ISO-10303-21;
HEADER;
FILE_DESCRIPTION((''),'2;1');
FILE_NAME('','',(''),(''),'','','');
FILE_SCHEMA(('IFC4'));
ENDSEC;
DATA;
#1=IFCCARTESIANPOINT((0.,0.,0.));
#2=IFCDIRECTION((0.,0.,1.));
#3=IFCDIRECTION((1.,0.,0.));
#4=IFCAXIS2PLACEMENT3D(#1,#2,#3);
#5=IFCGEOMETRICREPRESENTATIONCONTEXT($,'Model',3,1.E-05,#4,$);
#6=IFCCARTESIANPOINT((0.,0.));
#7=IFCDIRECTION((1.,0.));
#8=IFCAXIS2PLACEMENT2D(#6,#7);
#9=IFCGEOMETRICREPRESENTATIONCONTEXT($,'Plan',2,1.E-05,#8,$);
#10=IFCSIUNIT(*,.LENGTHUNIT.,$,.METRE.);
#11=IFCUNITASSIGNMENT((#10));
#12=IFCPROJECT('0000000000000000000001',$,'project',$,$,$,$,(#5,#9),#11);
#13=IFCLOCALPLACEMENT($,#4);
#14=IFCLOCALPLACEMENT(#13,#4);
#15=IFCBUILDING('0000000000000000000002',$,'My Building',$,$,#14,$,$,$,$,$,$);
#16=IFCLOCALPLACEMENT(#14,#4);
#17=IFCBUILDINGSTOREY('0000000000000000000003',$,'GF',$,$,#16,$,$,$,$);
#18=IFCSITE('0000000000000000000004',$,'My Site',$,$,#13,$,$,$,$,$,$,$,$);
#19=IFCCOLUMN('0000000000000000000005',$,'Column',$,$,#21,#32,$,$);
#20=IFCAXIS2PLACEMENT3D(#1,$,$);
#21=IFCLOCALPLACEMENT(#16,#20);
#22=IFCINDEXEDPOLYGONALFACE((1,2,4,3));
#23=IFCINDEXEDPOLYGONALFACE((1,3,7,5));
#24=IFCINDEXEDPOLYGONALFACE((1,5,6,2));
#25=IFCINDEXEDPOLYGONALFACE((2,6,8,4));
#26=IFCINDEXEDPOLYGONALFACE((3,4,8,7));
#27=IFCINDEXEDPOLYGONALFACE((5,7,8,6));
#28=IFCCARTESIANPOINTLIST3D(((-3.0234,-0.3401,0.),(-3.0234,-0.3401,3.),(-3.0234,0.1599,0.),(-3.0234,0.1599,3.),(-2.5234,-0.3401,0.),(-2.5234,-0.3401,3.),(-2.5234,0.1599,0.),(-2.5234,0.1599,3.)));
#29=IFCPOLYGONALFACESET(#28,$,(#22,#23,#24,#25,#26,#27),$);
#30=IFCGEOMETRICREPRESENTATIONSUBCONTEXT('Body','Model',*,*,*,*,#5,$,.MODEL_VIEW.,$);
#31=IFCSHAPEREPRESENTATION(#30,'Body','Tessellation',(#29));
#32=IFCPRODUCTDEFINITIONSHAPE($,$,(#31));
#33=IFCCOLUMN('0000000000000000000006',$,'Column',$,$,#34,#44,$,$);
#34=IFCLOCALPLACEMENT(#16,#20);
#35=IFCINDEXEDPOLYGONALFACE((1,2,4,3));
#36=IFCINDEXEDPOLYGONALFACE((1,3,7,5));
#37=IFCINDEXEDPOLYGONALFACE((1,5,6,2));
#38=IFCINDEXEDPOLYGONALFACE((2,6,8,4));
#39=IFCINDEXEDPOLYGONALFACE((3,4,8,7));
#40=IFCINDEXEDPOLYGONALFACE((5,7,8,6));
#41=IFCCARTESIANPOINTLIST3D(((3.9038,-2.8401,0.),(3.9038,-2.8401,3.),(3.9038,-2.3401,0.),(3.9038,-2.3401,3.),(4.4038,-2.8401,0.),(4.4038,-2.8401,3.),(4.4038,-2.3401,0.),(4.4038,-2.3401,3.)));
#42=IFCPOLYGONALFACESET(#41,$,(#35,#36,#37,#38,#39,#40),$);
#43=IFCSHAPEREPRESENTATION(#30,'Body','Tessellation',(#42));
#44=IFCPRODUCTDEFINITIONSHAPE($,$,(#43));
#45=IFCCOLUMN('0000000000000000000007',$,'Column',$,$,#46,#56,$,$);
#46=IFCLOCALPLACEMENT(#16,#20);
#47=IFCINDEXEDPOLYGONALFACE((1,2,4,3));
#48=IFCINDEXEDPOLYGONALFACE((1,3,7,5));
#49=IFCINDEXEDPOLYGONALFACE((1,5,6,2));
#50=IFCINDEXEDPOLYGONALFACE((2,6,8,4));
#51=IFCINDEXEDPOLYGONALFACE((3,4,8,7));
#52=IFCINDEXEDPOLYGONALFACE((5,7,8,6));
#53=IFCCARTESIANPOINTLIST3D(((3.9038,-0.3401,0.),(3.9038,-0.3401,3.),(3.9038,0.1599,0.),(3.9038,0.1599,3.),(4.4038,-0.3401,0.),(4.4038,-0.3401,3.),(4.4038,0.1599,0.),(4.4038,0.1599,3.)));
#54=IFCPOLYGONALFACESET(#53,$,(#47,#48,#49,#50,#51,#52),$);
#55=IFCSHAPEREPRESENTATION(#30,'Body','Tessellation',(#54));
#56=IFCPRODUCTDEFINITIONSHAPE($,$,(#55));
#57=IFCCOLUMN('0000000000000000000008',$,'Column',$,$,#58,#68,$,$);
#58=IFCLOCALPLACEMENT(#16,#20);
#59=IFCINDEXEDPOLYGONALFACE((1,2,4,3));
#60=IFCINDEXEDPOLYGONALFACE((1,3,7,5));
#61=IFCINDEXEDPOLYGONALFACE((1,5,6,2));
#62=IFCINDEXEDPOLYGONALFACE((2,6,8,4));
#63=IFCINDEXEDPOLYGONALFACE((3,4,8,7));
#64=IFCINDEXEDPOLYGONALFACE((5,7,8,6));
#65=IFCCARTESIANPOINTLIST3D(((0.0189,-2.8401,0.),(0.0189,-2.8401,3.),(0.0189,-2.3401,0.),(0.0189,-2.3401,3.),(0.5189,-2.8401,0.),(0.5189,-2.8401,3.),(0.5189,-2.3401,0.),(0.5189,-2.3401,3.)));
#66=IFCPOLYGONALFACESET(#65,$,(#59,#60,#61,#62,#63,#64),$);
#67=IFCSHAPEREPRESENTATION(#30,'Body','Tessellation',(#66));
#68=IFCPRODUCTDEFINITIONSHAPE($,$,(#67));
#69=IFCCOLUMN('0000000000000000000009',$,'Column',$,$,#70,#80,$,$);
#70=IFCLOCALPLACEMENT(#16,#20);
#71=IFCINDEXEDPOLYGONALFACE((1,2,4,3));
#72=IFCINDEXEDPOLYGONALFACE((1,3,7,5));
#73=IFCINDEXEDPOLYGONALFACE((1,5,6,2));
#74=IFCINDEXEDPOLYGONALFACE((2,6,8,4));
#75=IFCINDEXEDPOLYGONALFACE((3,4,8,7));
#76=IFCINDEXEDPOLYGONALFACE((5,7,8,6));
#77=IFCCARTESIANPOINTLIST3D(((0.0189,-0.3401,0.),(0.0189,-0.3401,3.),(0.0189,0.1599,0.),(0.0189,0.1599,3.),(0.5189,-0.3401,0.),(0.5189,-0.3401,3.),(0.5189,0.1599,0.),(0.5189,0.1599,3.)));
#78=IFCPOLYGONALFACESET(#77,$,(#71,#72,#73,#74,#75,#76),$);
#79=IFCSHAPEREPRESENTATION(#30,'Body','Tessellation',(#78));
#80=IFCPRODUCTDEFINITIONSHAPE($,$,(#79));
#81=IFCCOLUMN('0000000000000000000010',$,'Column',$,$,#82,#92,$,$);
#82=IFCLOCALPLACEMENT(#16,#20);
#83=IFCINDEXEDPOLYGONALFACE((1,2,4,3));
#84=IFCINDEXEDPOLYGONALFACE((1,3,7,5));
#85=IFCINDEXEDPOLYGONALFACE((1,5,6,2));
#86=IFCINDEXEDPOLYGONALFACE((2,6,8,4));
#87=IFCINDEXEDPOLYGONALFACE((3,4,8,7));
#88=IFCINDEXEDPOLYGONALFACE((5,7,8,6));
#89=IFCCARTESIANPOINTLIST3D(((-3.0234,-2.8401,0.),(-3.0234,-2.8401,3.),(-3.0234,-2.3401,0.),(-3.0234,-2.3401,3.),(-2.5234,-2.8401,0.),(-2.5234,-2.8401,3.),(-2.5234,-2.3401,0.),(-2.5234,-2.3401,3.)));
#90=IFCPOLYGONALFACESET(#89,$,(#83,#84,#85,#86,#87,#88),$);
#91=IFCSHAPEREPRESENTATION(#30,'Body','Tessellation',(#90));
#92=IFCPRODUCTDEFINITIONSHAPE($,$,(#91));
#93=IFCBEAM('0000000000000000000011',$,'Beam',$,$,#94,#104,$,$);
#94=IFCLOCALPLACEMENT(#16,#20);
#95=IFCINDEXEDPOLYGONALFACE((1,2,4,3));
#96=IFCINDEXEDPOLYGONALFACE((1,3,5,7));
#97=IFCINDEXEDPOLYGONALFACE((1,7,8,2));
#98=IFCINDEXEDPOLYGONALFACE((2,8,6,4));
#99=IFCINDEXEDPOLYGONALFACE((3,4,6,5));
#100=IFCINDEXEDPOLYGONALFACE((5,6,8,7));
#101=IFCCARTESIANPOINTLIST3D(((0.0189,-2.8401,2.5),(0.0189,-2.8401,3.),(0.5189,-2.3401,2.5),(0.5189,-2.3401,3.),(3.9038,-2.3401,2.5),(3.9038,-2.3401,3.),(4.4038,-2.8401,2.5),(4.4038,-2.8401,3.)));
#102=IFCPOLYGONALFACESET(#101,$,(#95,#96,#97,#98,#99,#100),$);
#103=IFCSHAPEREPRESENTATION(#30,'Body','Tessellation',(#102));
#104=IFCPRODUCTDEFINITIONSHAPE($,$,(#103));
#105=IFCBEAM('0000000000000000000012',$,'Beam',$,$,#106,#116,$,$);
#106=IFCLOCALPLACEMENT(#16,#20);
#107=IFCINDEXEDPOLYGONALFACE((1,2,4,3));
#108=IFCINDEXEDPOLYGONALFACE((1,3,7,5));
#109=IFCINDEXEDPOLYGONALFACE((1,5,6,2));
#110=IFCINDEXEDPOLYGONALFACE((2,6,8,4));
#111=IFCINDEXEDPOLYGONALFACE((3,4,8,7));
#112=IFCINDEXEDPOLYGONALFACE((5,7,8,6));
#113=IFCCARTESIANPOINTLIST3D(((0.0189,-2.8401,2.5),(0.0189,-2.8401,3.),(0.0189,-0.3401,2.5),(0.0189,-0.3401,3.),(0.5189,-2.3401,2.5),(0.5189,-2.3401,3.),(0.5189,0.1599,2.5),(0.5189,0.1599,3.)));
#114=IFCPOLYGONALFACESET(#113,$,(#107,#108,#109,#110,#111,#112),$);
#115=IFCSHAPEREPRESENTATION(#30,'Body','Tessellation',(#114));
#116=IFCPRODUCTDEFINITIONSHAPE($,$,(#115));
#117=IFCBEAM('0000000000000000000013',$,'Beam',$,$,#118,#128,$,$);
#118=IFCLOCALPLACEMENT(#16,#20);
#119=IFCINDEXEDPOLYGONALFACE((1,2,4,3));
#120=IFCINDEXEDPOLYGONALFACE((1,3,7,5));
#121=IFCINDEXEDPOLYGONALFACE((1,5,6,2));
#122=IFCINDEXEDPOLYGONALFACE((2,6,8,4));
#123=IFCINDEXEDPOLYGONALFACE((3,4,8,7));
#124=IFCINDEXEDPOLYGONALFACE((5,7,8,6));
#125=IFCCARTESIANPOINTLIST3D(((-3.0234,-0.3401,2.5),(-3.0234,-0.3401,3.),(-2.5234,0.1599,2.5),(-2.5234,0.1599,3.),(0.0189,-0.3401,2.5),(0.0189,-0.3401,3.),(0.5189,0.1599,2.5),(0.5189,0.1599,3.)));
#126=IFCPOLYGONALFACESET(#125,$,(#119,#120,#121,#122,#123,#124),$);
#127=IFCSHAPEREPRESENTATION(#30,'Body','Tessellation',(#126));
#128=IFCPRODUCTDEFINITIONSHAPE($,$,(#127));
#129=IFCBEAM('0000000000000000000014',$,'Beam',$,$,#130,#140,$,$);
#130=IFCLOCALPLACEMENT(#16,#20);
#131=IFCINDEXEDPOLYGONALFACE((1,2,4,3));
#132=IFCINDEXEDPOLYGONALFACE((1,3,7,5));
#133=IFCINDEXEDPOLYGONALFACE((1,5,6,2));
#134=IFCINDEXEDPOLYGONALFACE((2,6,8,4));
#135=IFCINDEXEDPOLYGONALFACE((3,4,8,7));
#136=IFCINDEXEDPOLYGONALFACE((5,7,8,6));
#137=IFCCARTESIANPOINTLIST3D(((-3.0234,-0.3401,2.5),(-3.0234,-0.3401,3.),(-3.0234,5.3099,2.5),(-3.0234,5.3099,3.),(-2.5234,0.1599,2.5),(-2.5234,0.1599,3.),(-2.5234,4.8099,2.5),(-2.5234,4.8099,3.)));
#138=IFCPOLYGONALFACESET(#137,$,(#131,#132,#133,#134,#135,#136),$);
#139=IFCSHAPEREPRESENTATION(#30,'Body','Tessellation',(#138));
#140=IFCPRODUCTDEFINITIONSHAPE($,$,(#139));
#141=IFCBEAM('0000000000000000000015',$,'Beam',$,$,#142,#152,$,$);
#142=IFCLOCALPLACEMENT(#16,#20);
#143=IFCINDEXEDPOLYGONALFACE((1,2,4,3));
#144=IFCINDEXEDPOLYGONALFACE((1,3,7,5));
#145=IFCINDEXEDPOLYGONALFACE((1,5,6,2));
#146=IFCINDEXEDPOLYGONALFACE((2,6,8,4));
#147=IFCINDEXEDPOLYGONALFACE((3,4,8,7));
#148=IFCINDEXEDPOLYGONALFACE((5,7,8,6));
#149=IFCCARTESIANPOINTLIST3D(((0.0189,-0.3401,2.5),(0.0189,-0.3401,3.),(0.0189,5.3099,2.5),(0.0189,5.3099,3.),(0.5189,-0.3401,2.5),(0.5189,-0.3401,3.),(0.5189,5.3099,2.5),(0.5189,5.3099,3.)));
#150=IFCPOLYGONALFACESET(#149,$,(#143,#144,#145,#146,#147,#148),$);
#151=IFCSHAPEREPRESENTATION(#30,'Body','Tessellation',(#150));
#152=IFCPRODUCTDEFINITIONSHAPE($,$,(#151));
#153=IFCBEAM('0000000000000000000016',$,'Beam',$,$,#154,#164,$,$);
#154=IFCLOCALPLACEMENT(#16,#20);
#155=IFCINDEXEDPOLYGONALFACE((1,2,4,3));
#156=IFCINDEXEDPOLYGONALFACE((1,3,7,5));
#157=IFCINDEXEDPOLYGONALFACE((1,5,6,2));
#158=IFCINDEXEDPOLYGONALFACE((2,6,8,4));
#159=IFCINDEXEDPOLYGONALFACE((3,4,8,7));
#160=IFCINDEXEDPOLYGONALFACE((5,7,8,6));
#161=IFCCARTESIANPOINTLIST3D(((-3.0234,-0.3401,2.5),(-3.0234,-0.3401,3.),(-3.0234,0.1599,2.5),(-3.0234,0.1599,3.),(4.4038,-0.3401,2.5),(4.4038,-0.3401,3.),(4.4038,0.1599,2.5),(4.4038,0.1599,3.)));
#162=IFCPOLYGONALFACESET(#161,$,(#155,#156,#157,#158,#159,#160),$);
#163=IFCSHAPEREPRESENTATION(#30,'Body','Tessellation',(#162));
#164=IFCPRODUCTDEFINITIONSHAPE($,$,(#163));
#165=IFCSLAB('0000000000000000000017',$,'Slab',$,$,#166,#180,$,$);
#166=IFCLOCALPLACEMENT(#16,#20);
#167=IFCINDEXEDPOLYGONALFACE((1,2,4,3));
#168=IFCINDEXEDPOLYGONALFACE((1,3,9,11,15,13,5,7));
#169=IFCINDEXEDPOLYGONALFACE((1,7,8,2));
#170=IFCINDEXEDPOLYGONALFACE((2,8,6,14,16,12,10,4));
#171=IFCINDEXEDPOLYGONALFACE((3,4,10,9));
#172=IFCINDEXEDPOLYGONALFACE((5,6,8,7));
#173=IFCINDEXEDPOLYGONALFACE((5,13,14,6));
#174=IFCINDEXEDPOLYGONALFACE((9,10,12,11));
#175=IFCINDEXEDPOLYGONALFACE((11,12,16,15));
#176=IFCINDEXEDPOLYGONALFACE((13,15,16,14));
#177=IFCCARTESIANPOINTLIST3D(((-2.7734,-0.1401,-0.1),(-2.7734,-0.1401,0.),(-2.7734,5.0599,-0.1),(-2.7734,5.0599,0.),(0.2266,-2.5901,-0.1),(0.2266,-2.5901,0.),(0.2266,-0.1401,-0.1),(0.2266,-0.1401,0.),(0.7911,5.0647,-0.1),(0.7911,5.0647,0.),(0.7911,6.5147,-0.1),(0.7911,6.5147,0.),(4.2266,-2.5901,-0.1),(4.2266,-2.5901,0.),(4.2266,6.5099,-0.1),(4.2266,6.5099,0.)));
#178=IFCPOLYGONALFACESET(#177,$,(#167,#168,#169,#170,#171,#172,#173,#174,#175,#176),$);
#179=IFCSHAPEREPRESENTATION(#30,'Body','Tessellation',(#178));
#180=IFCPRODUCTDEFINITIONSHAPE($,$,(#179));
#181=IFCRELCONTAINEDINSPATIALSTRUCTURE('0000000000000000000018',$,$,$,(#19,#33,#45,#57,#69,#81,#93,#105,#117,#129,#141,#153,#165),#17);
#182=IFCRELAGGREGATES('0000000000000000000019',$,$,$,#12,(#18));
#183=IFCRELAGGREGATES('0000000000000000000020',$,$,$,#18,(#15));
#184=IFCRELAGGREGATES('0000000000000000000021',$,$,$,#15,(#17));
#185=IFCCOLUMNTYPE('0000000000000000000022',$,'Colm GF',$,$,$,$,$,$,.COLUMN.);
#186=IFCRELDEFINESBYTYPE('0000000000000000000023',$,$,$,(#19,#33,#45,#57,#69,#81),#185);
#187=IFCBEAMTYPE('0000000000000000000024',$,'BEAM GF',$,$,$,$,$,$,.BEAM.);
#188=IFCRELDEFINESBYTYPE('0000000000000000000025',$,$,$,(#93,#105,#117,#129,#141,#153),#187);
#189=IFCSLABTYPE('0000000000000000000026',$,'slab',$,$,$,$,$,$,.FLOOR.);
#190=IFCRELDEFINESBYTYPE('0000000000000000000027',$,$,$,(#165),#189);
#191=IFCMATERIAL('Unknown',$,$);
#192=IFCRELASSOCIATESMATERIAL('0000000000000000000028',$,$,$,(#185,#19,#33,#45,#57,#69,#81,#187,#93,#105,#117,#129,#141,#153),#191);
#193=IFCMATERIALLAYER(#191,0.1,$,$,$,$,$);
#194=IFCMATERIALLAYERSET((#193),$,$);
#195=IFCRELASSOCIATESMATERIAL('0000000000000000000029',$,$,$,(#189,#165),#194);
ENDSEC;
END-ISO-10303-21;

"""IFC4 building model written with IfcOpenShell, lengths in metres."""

from ifc_helpers import new_model, si_unit, frame, origin_with_axes, origin_2d_with_axis, place, context, subcontext, project, spatial, indexed_curve, rectangle, outline, extrude, clip, halfspace, material, layer, layer_set, layer_usage, material_profile, profile_set, profile_usage, type_object, element, save


model = new_model("IFC4")

# Units and contexts
model_context = context("Model", 3, precision=1e-05, world=origin_with_axes())
plan_context = context("Plan", 2, precision=1e-05, world=origin_2d_with_axis())
body_context_1 = subcontext(model_context, "Body", "Model", "MODEL_VIEW")
ifc_project = project(units=[si_unit("LENGTHUNIT", "METRE")], contexts=[model_context, plan_context])

# Site, building, storey
site_placement = place(None, origin_with_axes())
site = spatial("IfcSite", under=ifc_project, at=site_placement, Name="My Site")
building_placement = place(site_placement, origin_with_axes())
building = spatial("IfcBuilding", under=site, at=building_placement, Name="My Building")
storey_placement = place(building_placement, origin_with_axes())
storey = spatial("IfcBuildingStorey", under=building, at=storey_placement, Name="GF")

# Columns
ifc_material = material(Name="Unknown")
ifc_material_profile_1 = material_profile(ifc_material, rectangle(XDim=0.5, YDim=0.5))
ifc_profile_set_1 = profile_set([ifc_material_profile_1])
ifc_profile_usage_1 = profile_usage(ifc_profile_set_1, cardinal=5)
column_type = type_object("IfcColumnType", Name="Colm GF", PredefinedType="COLUMN", material=ifc_profile_set_1)
column_1_placement = place(storey_placement, frame((-2.7734, -0.0901, 0.0), z_axis=(0.0, 0.0, 1.0), x_axis=(1.0, 0.0, 0.0)))
element("IfcColumn", 1, at=column_1_placement, inside=storey, type_object=column_type, material=ifc_profile_usage_1, Name="Column", context=body_context_1, shape_type="SweptSolid", body=[
    extrude(rectangle(XDim=0.5, YDim=0.5), origin_with_axes(), (0.0, 0.0, 1.0), 3.0),
])
ifc_profile_usage_2 = profile_usage(ifc_profile_set_1, cardinal=5)
column_2_placement = place(storey_placement, frame((4.1538, -2.5901, 0.0), z_axis=(0.0, 0.0, 1.0), x_axis=(1.0, 0.0, 0.0)))
element("IfcColumn", 2, at=column_2_placement, inside=storey, type_object=column_type, material=ifc_profile_usage_2, Name="Column", context=body_context_1, shape_type="SweptSolid", body=[
    extrude(rectangle(XDim=0.5, YDim=0.5), origin_with_axes(), (0.0, 0.0, 1.0), 3.0),
])
ifc_profile_usage_3 = profile_usage(ifc_profile_set_1, cardinal=5)
column_3_placement = place(storey_placement, frame((4.1538, -0.0901, 0.0), z_axis=(0.0, 0.0, 1.0), x_axis=(1.0, 0.0, 0.0)))
element("IfcColumn", 3, at=column_3_placement, inside=storey, type_object=column_type, material=ifc_profile_usage_3, Name="Column", context=body_context_1, shape_type="SweptSolid", body=[
    extrude(rectangle(XDim=0.5, YDim=0.5), origin_with_axes(), (0.0, 0.0, 1.0), 3.0),
])
ifc_profile_usage_4 = profile_usage(ifc_profile_set_1, cardinal=5)
column_4_placement = place(storey_placement, frame((0.2689, -2.5901, 0.0), z_axis=(0.0, 0.0, 1.0), x_axis=(1.0, 0.0, 0.0)))
element("IfcColumn", 4, at=column_4_placement, inside=storey, type_object=column_type, material=ifc_profile_usage_4, Name="Column", context=body_context_1, shape_type="SweptSolid", body=[
    extrude(rectangle(XDim=0.5, YDim=0.5), origin_with_axes(), (0.0, 0.0, 1.0), 3.0),
])
ifc_profile_usage_5 = profile_usage(ifc_profile_set_1, cardinal=5)
column_5_placement = place(storey_placement, frame((0.2689, -0.0901, 0.0), z_axis=(0.0, 0.0, 1.0), x_axis=(1.0, 0.0, 0.0)))
element("IfcColumn", 5, at=column_5_placement, inside=storey, type_object=column_type, material=ifc_profile_usage_5, Name="Column", context=body_context_1, shape_type="SweptSolid", body=[
    extrude(rectangle(XDim=0.5, YDim=0.5), origin_with_axes(), (0.0, 0.0, 1.0), 3.0),
])
ifc_profile_usage_6 = profile_usage(ifc_profile_set_1, cardinal=5)
column_6_placement = place(storey_placement, frame((-2.7734, -2.5901, 0.0), z_axis=(0.0, 0.0, 1.0), x_axis=(1.0, 0.0, 0.0)))
element("IfcColumn", 6, at=column_6_placement, inside=storey, type_object=column_type, material=ifc_profile_usage_6, Name="Column", context=body_context_1, shape_type="SweptSolid", body=[
    extrude(rectangle(XDim=0.5, YDim=0.5), origin_with_axes(), (0.0, 0.0, 1.0), 3.0),
])

# Beams
ifc_material_profile_2 = material_profile(ifc_material, rectangle(XDim=0.5, YDim=0.5))
ifc_profile_set_2 = profile_set([ifc_material_profile_2])
ifc_profile_usage_7 = profile_usage(ifc_profile_set_2, cardinal=7)
beam_type = type_object("IfcBeamType", Name="BEAM GF", PredefinedType="BEAM", material=ifc_profile_set_2)
beam_1_placement = place(storey_placement, frame((4.4038, -2.8401, 3.0), z_axis=(-1.0, 0.0, 0.0), x_axis=(0.0, -1.0, 0.0)))
element("IfcBeam", 7, at=beam_1_placement, inside=storey, type_object=beam_type, material=ifc_profile_usage_7, Name="Beam", context=body_context_1, shape_type="Clipping", body=[
    clip(clip(extrude(rectangle(XDim=0.5, YDim=0.5), frame((-0.25, -0.25, 0.0), z_axis=(0.0, 0.0, 1.0), x_axis=(1.0, 0.0, 0.0)), (0.0, 0.0, 1.0), 4.3849), halfspace(frame((0.0, -3.0, 4.3849), z_axis=(-0.707107, 0.0, 0.707107), x_axis=(0.0, 1.0, 0.0)), False)), halfspace(frame((0.0, -3.0, 0.0), z_axis=(-0.707107, 0.0, -0.707107), x_axis=(0.0, 1.0, 0.0)), False)),
])
ifc_profile_usage_8 = profile_usage(ifc_profile_set_2, cardinal=7)
beam_2_placement = place(storey_placement, frame((0.0189, -2.8401, 3.0), z_axis=(0.0, 1.0, 0.0), x_axis=(-1.0, 0.0, 0.0)))
element("IfcBeam", 8, at=beam_2_placement, inside=storey, type_object=beam_type, material=ifc_profile_usage_8, Name="Beam", context=body_context_1, shape_type="Clipping", body=[
    clip(clip(extrude(rectangle(XDim=0.5, YDim=0.5), frame((-0.25, -0.25, 0.0), z_axis=(0.0, 0.0, 1.0), x_axis=(1.0, 0.0, 0.0)), (0.0, 0.0, 1.0), 3.0), halfspace(frame((-0.5, -3.0, 3.0), z_axis=(0.707107, 0.0, 0.707107), x_axis=(0.0, -1.0, 0.0)), False)), halfspace(frame((0.0, -3.0, 0.0), z_axis=(-0.707107, 0.0, -0.707107), x_axis=(0.0, 1.0, 0.0)), False)),
])
ifc_profile_usage_9 = profile_usage(ifc_profile_set_2, cardinal=7)
beam_3_placement = place(storey_placement, frame((0.5189, -0.3401, 3.0), z_axis=(-1.0, 0.0, 0.0), x_axis=(0.0, -1.0, 0.0)))
element("IfcBeam", 9, at=beam_3_placement, inside=storey, type_object=beam_type, material=ifc_profile_usage_9, Name="Beam", context=body_context_1, shape_type="Clipping", body=[
    clip(clip(extrude(rectangle(XDim=0.5, YDim=0.5), frame((-0.25, -0.25, 0.0), z_axis=(0.0, 0.0, 1.0), x_axis=(1.0, 0.0, 0.0)), (0.0, 0.0, 1.0), 3.5422), halfspace(frame((0.0, -3.0, 3.5422), z_axis=(-0.707107, 0.0, 0.707107), x_axis=(0.0, 1.0, 0.0)), False)), halfspace(frame((-0.5, -3.0, 0.0), z_axis=(0.707107, 0.0, -0.707107), x_axis=(0.0, -1.0, 0.0)), False)),
])
ifc_profile_usage_10 = profile_usage(ifc_profile_set_2, cardinal=7)
beam_4_placement = place(storey_placement, frame((-3.0234, -0.3401, 3.0), z_axis=(0.0, 1.0, 0.0), x_axis=(-1.0, 0.0, 0.0)))
element("IfcBeam", 10, at=beam_4_placement, inside=storey, type_object=beam_type, material=ifc_profile_usage_10, Name="Beam", context=body_context_1, shape_type="Clipping", body=[
    clip(clip(extrude(rectangle(XDim=0.5, YDim=0.5), frame((-0.25, -0.25, 0.0), z_axis=(0.0, 0.0, 1.0), x_axis=(1.0, 0.0, 0.0)), (0.0, 0.0, 1.0), 5.65), halfspace(frame((0.0, -3.0, 5.65), z_axis=(-0.707107, 0.0, 0.707107), x_axis=(0.0, 1.0, 0.0)), False)), halfspace(frame((0.0, -3.0, 0.0), z_axis=(-0.707107, 0.0, -0.707107), x_axis=(0.0, 1.0, 0.0)), False)),
])
ifc_profile_usage_11 = profile_usage(ifc_profile_set_2, cardinal=7)
beam_5_placement = place(storey_placement, frame((0.0189, -0.3401, 3.0), z_axis=(0.0, 1.0, 0.0), x_axis=(-1.0, 0.0, 0.0)))
element("IfcBeam", 11, at=beam_5_placement, inside=storey, type_object=beam_type, material=ifc_profile_usage_11, Name="Beam", context=body_context_1, shape_type="SweptSolid", body=[
    extrude(rectangle(XDim=0.5, YDim=0.5), frame((-0.25, -0.25, 0.0), z_axis=(0.0, 0.0, 1.0), x_axis=(1.0, 0.0, 0.0)), (0.0, 0.0, 1.0), 5.65),
])
ifc_profile_usage_12 = profile_usage(ifc_profile_set_2, cardinal=7)
beam_6_placement = place(storey_placement, frame((4.4038, -0.3401, 3.0), z_axis=(-1.0, -0.000001, 0.0), x_axis=(0.000001, -1.0, 0.0)))
element("IfcBeam", 12, at=beam_6_placement, inside=storey, type_object=beam_type, material=ifc_profile_usage_12, Name="Beam", context=body_context_1, shape_type="SweptSolid", body=[
    extrude(rectangle(XDim=0.5, YDim=0.5), frame((-0.25, -0.25, 0.0), z_axis=(0.0, 0.0, 1.0), x_axis=(1.0, 0.0, 0.0)), (0.0, 0.0, 1.0), 7.4272),
])

# Slab
ifc_layer_1 = layer(ifc_material, 0.1)
ifc_layer_set_1 = layer_set([ifc_layer_1])
ifc_layer_usage_1 = layer_usage(ifc_layer_set_1, "AXIS3", "POSITIVE", -0.1)
slab_type_1 = type_object("IfcSlabType", Name="slab", PredefinedType="FLOOR", material=ifc_layer_set_1)
slab_1_placement = place(storey_placement, frame((0.2266, -2.5901, 0.0), z_axis=(0.0, 0.0, 1.0), x_axis=(1.0, 0.0, 0.0)))
element("IfcSlab", 13, at=slab_1_placement, inside=storey, type_object=slab_type_1, material=ifc_layer_usage_1, Name="Slab", context=body_context_1, shape_type="SweptSolid", body=[
    extrude(outline(indexed_curve([(0.0, 0.0), (4.0, 0.0), (4.0, 9.1), (0.5645, 9.1048), (0.5645, 7.6548), (-3.0, 7.65), (-3.0, 2.45), (0.0, 2.45), (0.0, 0.0)])), frame((0.0, 0.0, -0.1), z_axis=(0.0, 0.0, 1.0), x_axis=(1.0, 0.0, 0.0)), (0.0, 0.0, 1.0), 0.1),
])

save(model, "model.ifc")
